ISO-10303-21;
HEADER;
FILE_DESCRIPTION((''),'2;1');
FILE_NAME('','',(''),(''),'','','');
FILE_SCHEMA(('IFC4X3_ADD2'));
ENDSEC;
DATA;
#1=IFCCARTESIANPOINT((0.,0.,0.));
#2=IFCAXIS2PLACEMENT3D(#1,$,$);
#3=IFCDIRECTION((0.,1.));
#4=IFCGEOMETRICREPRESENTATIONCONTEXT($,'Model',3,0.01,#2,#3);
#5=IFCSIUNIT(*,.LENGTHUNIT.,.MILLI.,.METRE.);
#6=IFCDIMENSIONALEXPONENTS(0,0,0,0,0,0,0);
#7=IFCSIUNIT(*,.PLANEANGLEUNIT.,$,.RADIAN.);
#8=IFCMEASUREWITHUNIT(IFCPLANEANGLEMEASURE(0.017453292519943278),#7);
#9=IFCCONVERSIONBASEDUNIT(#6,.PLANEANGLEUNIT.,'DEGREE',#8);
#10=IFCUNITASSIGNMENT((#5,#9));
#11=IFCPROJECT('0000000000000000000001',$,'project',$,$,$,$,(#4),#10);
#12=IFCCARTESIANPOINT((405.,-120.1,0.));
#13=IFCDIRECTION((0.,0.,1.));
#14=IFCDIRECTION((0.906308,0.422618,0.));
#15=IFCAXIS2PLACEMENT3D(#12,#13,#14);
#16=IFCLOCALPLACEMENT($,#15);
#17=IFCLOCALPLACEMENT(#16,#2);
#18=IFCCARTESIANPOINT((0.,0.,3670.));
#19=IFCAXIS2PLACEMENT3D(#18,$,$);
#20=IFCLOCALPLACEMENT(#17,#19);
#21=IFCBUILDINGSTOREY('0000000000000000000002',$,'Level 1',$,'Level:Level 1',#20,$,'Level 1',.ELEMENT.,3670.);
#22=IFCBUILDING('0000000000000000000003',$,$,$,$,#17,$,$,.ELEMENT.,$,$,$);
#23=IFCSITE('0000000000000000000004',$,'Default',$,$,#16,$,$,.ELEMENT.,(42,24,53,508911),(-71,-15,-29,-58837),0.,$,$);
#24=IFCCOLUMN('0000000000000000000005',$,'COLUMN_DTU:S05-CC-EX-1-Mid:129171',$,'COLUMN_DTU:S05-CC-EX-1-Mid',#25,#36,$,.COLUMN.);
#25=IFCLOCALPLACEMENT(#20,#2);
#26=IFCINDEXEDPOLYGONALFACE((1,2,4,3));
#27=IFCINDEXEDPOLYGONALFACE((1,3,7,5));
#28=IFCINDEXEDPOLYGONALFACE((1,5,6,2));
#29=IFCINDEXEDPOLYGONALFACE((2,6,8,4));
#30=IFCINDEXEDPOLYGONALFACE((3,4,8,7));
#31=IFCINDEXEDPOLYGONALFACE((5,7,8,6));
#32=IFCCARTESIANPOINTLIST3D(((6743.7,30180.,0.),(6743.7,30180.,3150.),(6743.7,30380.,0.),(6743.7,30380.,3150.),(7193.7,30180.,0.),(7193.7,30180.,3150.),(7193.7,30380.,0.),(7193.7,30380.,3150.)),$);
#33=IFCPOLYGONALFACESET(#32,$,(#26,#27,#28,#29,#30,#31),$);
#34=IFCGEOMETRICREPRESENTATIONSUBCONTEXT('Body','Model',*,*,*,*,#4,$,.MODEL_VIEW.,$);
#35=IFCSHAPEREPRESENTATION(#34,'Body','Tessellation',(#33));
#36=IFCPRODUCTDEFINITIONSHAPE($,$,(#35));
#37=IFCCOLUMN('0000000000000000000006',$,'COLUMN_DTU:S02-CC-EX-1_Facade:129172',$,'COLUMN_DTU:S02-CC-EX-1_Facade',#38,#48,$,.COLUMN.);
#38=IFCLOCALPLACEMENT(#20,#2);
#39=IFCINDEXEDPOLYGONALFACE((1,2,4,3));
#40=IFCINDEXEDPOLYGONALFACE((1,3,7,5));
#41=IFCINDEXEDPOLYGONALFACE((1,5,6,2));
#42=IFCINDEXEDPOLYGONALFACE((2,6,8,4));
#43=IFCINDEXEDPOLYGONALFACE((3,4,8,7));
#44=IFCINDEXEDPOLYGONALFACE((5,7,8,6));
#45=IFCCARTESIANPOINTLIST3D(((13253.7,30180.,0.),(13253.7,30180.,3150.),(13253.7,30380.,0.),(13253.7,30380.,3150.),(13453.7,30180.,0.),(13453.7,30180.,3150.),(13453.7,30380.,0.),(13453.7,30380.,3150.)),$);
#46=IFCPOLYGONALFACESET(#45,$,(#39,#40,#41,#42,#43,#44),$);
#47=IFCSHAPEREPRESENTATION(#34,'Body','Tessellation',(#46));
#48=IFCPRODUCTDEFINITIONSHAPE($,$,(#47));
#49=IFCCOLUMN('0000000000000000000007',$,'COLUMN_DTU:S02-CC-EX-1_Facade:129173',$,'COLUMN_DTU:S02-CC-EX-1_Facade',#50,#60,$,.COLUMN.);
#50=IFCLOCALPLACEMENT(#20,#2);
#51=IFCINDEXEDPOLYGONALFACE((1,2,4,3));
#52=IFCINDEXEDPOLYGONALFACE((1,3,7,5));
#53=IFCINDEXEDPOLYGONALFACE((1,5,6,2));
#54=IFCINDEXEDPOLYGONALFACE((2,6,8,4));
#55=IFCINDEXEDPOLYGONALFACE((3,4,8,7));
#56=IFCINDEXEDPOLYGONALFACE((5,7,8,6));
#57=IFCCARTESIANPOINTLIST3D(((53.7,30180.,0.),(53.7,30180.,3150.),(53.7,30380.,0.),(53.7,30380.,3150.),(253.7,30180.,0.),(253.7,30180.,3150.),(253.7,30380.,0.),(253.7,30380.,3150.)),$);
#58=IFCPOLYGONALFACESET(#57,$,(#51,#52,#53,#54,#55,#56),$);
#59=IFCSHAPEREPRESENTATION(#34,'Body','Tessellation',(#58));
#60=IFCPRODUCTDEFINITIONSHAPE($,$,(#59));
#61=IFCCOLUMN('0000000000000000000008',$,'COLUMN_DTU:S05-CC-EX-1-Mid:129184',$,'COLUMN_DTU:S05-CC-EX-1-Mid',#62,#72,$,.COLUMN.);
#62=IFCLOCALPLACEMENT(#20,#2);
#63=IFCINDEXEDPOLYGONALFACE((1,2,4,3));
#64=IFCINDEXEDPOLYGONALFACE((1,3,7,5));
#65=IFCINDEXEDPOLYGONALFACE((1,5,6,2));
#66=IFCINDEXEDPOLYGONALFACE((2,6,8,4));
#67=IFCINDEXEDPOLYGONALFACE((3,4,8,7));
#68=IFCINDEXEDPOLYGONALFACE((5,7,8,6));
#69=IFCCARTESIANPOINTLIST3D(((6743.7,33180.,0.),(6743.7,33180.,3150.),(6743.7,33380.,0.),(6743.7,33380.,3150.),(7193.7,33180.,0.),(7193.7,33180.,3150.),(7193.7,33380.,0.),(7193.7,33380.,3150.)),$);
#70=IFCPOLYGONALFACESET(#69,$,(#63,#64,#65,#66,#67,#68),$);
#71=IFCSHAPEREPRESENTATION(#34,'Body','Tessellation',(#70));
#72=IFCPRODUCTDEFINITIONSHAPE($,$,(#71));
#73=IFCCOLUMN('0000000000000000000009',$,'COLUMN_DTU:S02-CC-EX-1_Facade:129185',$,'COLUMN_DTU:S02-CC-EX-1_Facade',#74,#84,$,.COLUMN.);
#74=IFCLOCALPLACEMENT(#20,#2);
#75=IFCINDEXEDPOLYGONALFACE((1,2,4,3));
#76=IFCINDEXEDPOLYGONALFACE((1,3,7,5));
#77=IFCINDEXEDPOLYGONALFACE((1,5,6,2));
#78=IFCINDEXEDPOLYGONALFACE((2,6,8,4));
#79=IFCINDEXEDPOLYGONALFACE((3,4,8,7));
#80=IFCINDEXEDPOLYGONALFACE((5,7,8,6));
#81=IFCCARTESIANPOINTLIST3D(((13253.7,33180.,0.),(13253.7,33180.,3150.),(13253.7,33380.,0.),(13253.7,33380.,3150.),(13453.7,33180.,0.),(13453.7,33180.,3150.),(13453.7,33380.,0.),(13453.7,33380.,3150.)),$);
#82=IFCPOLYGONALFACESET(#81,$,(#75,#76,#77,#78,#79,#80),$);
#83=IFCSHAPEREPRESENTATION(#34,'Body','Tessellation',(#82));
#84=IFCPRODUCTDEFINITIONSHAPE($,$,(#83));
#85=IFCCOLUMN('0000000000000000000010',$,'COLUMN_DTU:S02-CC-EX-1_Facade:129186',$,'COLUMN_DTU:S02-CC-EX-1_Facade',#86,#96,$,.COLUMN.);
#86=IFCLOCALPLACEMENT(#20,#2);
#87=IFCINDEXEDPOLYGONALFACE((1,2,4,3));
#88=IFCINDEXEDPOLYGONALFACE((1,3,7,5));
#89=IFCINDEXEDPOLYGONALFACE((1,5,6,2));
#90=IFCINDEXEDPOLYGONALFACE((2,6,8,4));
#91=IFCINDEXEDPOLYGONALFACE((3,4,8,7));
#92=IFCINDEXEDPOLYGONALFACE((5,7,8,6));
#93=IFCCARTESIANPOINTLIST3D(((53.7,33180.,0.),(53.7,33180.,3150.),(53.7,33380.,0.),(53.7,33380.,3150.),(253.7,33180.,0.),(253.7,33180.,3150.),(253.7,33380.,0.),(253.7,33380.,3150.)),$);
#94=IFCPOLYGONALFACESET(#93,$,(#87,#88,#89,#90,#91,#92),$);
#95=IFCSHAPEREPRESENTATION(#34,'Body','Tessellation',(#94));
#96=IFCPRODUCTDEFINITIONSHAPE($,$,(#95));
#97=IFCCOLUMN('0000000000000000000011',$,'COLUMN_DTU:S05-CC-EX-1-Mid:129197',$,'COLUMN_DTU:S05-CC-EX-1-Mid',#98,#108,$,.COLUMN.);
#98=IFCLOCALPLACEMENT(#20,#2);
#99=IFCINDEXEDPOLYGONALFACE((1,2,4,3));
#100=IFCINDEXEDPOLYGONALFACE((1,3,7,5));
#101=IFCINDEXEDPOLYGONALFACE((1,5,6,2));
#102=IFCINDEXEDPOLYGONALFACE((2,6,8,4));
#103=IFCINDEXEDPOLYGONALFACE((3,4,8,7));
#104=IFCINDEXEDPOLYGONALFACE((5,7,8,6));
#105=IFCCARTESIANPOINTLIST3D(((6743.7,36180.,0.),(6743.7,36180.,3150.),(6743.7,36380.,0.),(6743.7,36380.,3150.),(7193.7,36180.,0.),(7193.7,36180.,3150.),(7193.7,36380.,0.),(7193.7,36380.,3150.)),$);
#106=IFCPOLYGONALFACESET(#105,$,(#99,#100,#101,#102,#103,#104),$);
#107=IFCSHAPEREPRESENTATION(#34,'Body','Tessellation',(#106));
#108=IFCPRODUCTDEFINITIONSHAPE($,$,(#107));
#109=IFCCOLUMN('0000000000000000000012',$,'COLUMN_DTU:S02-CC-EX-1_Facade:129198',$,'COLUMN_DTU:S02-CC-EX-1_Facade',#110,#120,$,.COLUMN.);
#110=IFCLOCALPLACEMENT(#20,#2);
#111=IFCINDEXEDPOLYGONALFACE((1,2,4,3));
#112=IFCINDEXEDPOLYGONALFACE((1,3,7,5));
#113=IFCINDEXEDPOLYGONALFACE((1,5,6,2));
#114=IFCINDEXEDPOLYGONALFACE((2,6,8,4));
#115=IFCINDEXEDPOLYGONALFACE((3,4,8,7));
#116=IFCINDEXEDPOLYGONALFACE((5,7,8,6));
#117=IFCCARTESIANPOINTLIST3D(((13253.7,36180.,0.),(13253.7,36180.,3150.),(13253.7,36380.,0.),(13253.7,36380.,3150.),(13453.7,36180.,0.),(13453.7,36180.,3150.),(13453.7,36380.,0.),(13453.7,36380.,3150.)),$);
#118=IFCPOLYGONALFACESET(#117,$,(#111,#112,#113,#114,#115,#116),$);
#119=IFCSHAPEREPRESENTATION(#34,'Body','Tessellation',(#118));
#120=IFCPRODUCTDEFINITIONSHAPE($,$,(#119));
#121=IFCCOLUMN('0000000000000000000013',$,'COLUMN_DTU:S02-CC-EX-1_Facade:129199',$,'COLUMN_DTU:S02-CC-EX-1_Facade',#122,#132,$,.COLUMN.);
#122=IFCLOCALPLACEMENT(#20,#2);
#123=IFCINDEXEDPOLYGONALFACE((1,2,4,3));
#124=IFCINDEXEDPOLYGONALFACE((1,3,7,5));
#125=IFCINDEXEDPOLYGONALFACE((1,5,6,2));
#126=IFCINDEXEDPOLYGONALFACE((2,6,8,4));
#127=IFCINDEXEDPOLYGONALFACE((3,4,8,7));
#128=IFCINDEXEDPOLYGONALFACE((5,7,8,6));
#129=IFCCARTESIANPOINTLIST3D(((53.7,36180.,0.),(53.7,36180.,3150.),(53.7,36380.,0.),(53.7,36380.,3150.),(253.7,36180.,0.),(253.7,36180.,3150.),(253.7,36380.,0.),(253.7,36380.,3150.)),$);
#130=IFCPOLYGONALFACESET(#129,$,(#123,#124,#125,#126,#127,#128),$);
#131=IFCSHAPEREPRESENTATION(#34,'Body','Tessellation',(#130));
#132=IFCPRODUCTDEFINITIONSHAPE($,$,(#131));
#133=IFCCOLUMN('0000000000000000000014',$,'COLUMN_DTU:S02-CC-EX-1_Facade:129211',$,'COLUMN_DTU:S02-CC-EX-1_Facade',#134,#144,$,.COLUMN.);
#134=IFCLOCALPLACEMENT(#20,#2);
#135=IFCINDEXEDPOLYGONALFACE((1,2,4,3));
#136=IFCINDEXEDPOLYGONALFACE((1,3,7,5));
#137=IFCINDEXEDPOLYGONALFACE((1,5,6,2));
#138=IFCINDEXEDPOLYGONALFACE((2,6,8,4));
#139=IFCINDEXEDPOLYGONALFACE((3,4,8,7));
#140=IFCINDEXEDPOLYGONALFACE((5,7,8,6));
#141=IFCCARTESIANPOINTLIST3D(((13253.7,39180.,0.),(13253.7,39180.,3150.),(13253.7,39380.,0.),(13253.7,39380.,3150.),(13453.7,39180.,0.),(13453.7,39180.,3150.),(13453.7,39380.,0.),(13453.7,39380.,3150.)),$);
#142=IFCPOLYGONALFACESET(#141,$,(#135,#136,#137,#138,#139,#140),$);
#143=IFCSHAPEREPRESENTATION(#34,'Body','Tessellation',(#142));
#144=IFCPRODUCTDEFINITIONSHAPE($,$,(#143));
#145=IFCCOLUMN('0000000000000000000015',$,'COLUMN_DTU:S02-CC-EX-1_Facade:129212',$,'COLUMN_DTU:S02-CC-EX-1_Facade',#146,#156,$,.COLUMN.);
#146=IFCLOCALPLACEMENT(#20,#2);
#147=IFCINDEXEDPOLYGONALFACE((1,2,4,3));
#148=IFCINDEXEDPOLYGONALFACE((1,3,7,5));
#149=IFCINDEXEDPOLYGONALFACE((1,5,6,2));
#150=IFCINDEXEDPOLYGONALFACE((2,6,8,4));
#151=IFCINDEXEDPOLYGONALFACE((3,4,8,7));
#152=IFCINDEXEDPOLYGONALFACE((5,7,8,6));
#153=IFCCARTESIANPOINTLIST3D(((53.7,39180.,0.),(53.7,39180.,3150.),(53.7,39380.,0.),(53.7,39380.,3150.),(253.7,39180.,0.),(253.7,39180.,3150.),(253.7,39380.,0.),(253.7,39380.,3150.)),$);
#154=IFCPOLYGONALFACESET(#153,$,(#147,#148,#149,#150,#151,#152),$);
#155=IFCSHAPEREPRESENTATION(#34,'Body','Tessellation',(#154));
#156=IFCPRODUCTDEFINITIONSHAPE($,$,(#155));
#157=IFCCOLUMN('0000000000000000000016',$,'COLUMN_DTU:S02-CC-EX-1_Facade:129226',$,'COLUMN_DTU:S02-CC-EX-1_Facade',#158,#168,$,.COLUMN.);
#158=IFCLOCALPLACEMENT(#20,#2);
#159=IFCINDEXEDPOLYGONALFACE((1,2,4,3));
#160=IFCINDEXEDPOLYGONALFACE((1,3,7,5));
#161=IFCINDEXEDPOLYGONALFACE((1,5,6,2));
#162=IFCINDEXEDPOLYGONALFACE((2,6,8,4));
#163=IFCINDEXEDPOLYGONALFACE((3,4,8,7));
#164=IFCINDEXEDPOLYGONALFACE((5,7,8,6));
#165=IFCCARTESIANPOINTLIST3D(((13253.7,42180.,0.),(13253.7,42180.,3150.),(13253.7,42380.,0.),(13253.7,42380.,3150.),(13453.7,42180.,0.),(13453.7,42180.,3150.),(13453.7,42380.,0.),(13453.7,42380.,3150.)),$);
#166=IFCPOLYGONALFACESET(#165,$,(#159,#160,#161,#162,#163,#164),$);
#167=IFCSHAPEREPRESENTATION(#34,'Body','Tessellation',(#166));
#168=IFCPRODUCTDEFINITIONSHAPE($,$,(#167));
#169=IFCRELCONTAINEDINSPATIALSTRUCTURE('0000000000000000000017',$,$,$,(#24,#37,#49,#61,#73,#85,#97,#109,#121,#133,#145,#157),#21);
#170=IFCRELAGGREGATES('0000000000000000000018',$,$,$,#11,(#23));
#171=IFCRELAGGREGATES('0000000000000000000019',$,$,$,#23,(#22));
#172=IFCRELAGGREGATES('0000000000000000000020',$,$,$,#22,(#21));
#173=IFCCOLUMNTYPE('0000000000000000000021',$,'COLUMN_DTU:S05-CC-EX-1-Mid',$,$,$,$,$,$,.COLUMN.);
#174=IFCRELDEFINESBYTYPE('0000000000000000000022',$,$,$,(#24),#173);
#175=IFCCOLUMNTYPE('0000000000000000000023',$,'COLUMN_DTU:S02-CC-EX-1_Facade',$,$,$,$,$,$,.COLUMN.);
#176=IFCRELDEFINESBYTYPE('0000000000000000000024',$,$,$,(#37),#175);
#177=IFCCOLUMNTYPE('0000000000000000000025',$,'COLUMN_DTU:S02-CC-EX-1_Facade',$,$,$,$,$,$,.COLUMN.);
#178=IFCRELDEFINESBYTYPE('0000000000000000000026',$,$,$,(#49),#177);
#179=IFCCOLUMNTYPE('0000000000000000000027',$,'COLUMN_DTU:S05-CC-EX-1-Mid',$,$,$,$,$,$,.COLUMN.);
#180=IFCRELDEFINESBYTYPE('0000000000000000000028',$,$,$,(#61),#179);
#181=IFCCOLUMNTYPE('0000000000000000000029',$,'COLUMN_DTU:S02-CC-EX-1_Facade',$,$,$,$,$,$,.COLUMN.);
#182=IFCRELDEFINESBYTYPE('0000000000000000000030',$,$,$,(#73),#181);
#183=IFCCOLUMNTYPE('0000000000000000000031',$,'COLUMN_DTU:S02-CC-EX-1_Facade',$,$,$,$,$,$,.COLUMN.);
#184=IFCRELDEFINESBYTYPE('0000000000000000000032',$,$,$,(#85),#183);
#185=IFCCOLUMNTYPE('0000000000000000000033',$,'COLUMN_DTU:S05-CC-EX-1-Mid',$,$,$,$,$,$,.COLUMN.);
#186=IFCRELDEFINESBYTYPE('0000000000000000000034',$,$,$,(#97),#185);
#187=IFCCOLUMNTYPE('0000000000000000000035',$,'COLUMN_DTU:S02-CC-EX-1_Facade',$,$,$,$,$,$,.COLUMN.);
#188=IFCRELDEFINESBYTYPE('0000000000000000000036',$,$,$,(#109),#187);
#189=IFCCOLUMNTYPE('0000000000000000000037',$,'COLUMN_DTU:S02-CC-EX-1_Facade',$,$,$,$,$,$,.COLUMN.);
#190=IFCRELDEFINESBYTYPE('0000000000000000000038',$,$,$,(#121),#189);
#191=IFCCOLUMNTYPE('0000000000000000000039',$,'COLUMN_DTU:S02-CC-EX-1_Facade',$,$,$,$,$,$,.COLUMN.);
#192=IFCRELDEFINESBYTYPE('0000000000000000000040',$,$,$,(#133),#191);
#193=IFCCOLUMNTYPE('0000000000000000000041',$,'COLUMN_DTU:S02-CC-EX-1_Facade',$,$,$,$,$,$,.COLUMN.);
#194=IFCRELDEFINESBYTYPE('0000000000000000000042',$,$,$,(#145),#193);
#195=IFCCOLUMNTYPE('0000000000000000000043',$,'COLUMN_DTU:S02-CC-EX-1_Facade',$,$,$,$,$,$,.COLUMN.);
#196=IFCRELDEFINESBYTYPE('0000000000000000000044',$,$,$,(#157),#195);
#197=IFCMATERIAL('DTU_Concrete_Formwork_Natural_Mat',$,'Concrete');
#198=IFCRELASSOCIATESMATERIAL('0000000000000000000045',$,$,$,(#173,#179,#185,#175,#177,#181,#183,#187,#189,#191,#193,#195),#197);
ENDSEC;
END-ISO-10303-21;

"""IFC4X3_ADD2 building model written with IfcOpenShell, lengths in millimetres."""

from ifc_helpers import new_model, entity, si_unit, converted_unit, direction, frame, frame_2d, origin, origin_2d_with_axis, place, context, subcontext, project, spatial, rectangle, extrude, source, transform, mapped, material, material_profile, profile_set, type_object, type_shapes, element, save


model = new_model("IFC4X3_ADD2")

# Units and contexts
model_context = context("Model", 3, precision=0.01, world=origin(), true_north=direction((0.0, 1.0)))
body_context = subcontext(model_context, "Body", "Model", "MODEL_VIEW")
ifc_project = project(units=[si_unit("LENGTHUNIT", "METRE", prefix="MILLI"), converted_unit("PLANEANGLEUNIT", "DEGREE", entity("IfcPlaneAngleMeasure", 0.017453292519943278), si_unit("PLANEANGLEUNIT", "RADIAN"), dimensions=[0, 0, 0, 0, 0, 0, 0])], contexts=[model_context])

# Site, building, storey
site_placement = place(None, frame((405.0, -120.1, 0.0), z_axis=(0.0, 0.0, 1.0), x_axis=(0.906308, 0.422618, 0.0)))
site = spatial("IfcSite", under=ifc_project, at=site_placement, Name="Default", CompositionType="ELEMENT", RefLatitude=(42, 24, 53, 508911), RefLongitude=(-71, -15, -29, -58837), RefElevation=0.0)
building_placement = place(site_placement, origin())
building = spatial("IfcBuilding", under=site, at=building_placement, CompositionType="ELEMENT")
storey_placement = place(building_placement, frame((0.0, 0.0, 3670.0)))
storey = spatial("IfcBuildingStorey", under=building, at=storey_placement, Name="Level 1", ObjectType="Level:Level 1", LongName="Level 1", CompositionType="ELEMENT", Elevation=3670.0)

# Columns
ifc_material = material(Name="DTU_Concrete_Formwork_Natural_Mat", Category="Concrete")
ifc_material_profile_1 = material_profile(ifc_material, rectangle(XDim=200.0, YDim=450.0, at=origin_2d_with_axis()), Name="S05-CC-EX-1-Mid")
ifc_profile_set_1 = profile_set([ifc_material_profile_1], Name="S05-CC-EX-1-Mid")
column_type_1 = type_object("IfcColumnType", Name="COLUMN_DTU:S05-CC-EX-1-Mid", PredefinedType="COLUMN", material=ifc_profile_set_1)
shared_shape_1 = source(origin(), body_context, "Body", "SweptSolid", [
    extrude(rectangle(XDim=200.0, YDim=450.0, at=origin_2d_with_axis()), frame((6968.7, 30280.0, 3670.0), z_axis=(0.0, 0.0, 1.0), x_axis=(0.0, 1.0, 0.0)), (0.0, 0.0, 1.0), 3150.0),
])
type_shapes(column_type_1, [shared_shape_1])
column_1_placement = place(storey_placement, frame((0.0, 0.0, -3670.0)))
element("IfcColumn", 1, at=column_1_placement, inside=storey, type_object=column_type_1, Name="COLUMN_DTU:S05-CC-EX-1-Mid:129171", ObjectType="COLUMN_DTU:S05-CC-EX-1-Mid", PredefinedType="COLUMN", context=body_context, shape_type="MappedRepresentation", body=[
    mapped(shared_shape_1, transform((0.0, 0.0, 0.0), scale=1.0)),
])
ifc_material_profile_2 = material_profile(ifc_material, rectangle(XDim=200.0, YDim=200.0, at=frame_2d((0.0, 0.0), x_axis=(1.0, 0.0))), Name="S02-CC-EX-1_Facade")
ifc_profile_set_2 = profile_set([ifc_material_profile_2], Name="S02-CC-EX-1_Facade")
column_type_2 = type_object("IfcColumnType", Name="COLUMN_DTU:S02-CC-EX-1_Facade", PredefinedType="COLUMN", material=ifc_profile_set_2)
shared_shape_2 = source(origin(), body_context, "Body", "SweptSolid", [
    extrude(rectangle(XDim=200.0, YDim=200.0, at=frame_2d((0.0, 0.0), x_axis=(1.0, 0.0))), frame((13353.7, 30280.0, 3670.0), z_axis=(0.0, 0.0, 1.0), x_axis=(0.0, -1.0, 0.0)), (0.0, 0.0, 1.0), 3150.0),
])
type_shapes(column_type_2, [shared_shape_2])
column_2_placement = place(storey_placement, frame((0.0, 0.0, -3670.0)))
element("IfcColumn", 2, at=column_2_placement, inside=storey, type_object=column_type_2, Name="COLUMN_DTU:S02-CC-EX-1_Facade:129172", ObjectType="COLUMN_DTU:S02-CC-EX-1_Facade", PredefinedType="COLUMN", context=body_context, shape_type="MappedRepresentation", body=[
    mapped(shared_shape_2, transform((0.0, 0.0, 0.0), scale=1.0)),
])
column_type_3 = type_object("IfcColumnType", Name="COLUMN_DTU:S02-CC-EX-1_Facade", PredefinedType="COLUMN", material=ifc_profile_set_2)
shared_shape_3 = source(origin(), body_context, "Body", "SweptSolid", [
    extrude(rectangle(XDim=200.0, YDim=200.0, at=frame_2d((0.0, 0.0), x_axis=(1.0, 0.0))), frame((153.7, 30280.0, 3670.0), z_axis=(0.0, 0.0, 1.0), x_axis=(0.0, -1.0, 0.0)), (0.0, 0.0, 1.0), 3150.0),
])
type_shapes(column_type_3, [shared_shape_3])
column_3_placement = place(storey_placement, frame((0.0, 0.0, -3670.0)))
element("IfcColumn", 3, at=column_3_placement, inside=storey, type_object=column_type_3, Name="COLUMN_DTU:S02-CC-EX-1_Facade:129173", ObjectType="COLUMN_DTU:S02-CC-EX-1_Facade", PredefinedType="COLUMN", context=body_context, shape_type="MappedRepresentation", body=[
    mapped(shared_shape_3, transform((0.0, 0.0, 0.0), scale=1.0)),
])
column_type_4 = type_object("IfcColumnType", Name="COLUMN_DTU:S05-CC-EX-1-Mid", PredefinedType="COLUMN", material=ifc_profile_set_1)
shared_shape_4 = source(origin(), body_context, "Body", "SweptSolid", [
    extrude(rectangle(XDim=200.0, YDim=450.0, at=origin_2d_with_axis()), frame((6968.7, 33280.0, 3670.0), z_axis=(0.0, 0.0, 1.0), x_axis=(0.0, 1.0, 0.0)), (0.0, 0.0, 1.0), 3150.0),
])
type_shapes(column_type_4, [shared_shape_4])
column_4_placement = place(storey_placement, frame((0.0, 0.0, -3670.0)))
element("IfcColumn", 4, at=column_4_placement, inside=storey, type_object=column_type_4, Name="COLUMN_DTU:S05-CC-EX-1-Mid:129184", ObjectType="COLUMN_DTU:S05-CC-EX-1-Mid", PredefinedType="COLUMN", context=body_context, shape_type="MappedRepresentation", body=[
    mapped(shared_shape_4, transform((0.0, 0.0, 0.0), scale=1.0)),
])
column_type_5 = type_object("IfcColumnType", Name="COLUMN_DTU:S02-CC-EX-1_Facade", PredefinedType="COLUMN", material=ifc_profile_set_2)
shared_shape_5 = source(origin(), body_context, "Body", "SweptSolid", [
    extrude(rectangle(XDim=200.0, YDim=200.0, at=frame_2d((0.0, 0.0), x_axis=(1.0, 0.0))), frame((13353.7, 33280.0, 3670.0), z_axis=(0.0, 0.0, 1.0), x_axis=(0.0, -1.0, 0.0)), (0.0, 0.0, 1.0), 3150.0),
])
type_shapes(column_type_5, [shared_shape_5])
column_5_placement = place(storey_placement, frame((0.0, 0.0, -3670.0)))
element("IfcColumn", 5, at=column_5_placement, inside=storey, type_object=column_type_5, Name="COLUMN_DTU:S02-CC-EX-1_Facade:129185", ObjectType="COLUMN_DTU:S02-CC-EX-1_Facade", PredefinedType="COLUMN", context=body_context, shape_type="MappedRepresentation", body=[
    mapped(shared_shape_5, transform((0.0, 0.0, 0.0), scale=1.0)),
])
column_type_6 = type_object("IfcColumnType", Name="COLUMN_DTU:S02-CC-EX-1_Facade", PredefinedType="COLUMN", material=ifc_profile_set_2)
shared_shape_6 = source(origin(), body_context, "Body", "SweptSolid", [
    extrude(rectangle(XDim=200.0, YDim=200.0, at=frame_2d((0.0, 0.0), x_axis=(1.0, 0.0))), frame((153.7, 33280.0, 3670.0), z_axis=(0.0, 0.0, 1.0), x_axis=(0.0, -1.0, 0.0)), (0.0, 0.0, 1.0), 3150.0),
])
type_shapes(column_type_6, [shared_shape_6])
column_6_placement = place(storey_placement, frame((0.0, 0.0, -3670.0)))
element("IfcColumn", 6, at=column_6_placement, inside=storey, type_object=column_type_6, Name="COLUMN_DTU:S02-CC-EX-1_Facade:129186", ObjectType="COLUMN_DTU:S02-CC-EX-1_Facade", PredefinedType="COLUMN", context=body_context, shape_type="MappedRepresentation", body=[
    mapped(shared_shape_6, transform((0.0, 0.0, 0.0), scale=1.0)),
])
column_type_7 = type_object("IfcColumnType", Name="COLUMN_DTU:S05-CC-EX-1-Mid", PredefinedType="COLUMN", material=ifc_profile_set_1)
shared_shape_7 = source(origin(), body_context, "Body", "SweptSolid", [
    extrude(rectangle(XDim=200.0, YDim=450.0, at=origin_2d_with_axis()), frame((6968.7, 36280.0, 3670.0), z_axis=(0.0, 0.0, 1.0), x_axis=(0.0, 1.0, 0.0)), (0.0, 0.0, 1.0), 3150.0),
])
type_shapes(column_type_7, [shared_shape_7])
column_7_placement = place(storey_placement, frame((0.0, 0.0, -3670.0)))
element("IfcColumn", 7, at=column_7_placement, inside=storey, type_object=column_type_7, Name="COLUMN_DTU:S05-CC-EX-1-Mid:129197", ObjectType="COLUMN_DTU:S05-CC-EX-1-Mid", PredefinedType="COLUMN", context=body_context, shape_type="MappedRepresentation", body=[
    mapped(shared_shape_7, transform((0.0, 0.0, 0.0), scale=1.0)),
])
column_type_8 = type_object("IfcColumnType", Name="COLUMN_DTU:S02-CC-EX-1_Facade", PredefinedType="COLUMN", material=ifc_profile_set_2)
shared_shape_8 = source(origin(), body_context, "Body", "SweptSolid", [
    extrude(rectangle(XDim=200.0, YDim=200.0, at=frame_2d((0.0, 0.0), x_axis=(1.0, 0.0))), frame((13353.7, 36280.0, 3670.0), z_axis=(0.0, 0.0, 1.0), x_axis=(0.0, -1.0, 0.0)), (0.0, 0.0, 1.0), 3150.0),
])
type_shapes(column_type_8, [shared_shape_8])
column_8_placement = place(storey_placement, frame((0.0, 0.0, -3670.0)))
element("IfcColumn", 8, at=column_8_placement, inside=storey, type_object=column_type_8, Name="COLUMN_DTU:S02-CC-EX-1_Facade:129198", ObjectType="COLUMN_DTU:S02-CC-EX-1_Facade", PredefinedType="COLUMN", context=body_context, shape_type="MappedRepresentation", body=[
    mapped(shared_shape_8, transform((0.0, 0.0, 0.0), scale=1.0)),
])
column_type_9 = type_object("IfcColumnType", Name="COLUMN_DTU:S02-CC-EX-1_Facade", PredefinedType="COLUMN", material=ifc_profile_set_2)
shared_shape_9 = source(origin(), body_context, "Body", "SweptSolid", [
    extrude(rectangle(XDim=200.0, YDim=200.0, at=frame_2d((0.0, 0.0), x_axis=(1.0, 0.0))), frame((153.7, 36280.0, 3670.0), z_axis=(0.0, 0.0, 1.0), x_axis=(0.0, -1.0, 0.0)), (0.0, 0.0, 1.0), 3150.0),
])
type_shapes(column_type_9, [shared_shape_9])
column_9_placement = place(storey_placement, frame((0.0, 0.0, -3670.0)))
element("IfcColumn", 9, at=column_9_placement, inside=storey, type_object=column_type_9, Name="COLUMN_DTU:S02-CC-EX-1_Facade:129199", ObjectType="COLUMN_DTU:S02-CC-EX-1_Facade", PredefinedType="COLUMN", context=body_context, shape_type="MappedRepresentation", body=[
    mapped(shared_shape_9, transform((0.0, 0.0, 0.0), scale=1.0)),
])
column_type_10 = type_object("IfcColumnType", Name="COLUMN_DTU:S02-CC-EX-1_Facade", PredefinedType="COLUMN", material=ifc_profile_set_2)
shared_shape_10 = source(origin(), body_context, "Body", "SweptSolid", [
    extrude(rectangle(XDim=200.0, YDim=200.0, at=frame_2d((0.0, 0.0), x_axis=(1.0, 0.0))), frame((13353.7, 39280.0, 3670.0), z_axis=(0.0, 0.0, 1.0), x_axis=(0.0, -1.0, 0.0)), (0.0, 0.0, 1.0), 3150.0),
])
type_shapes(column_type_10, [shared_shape_10])
column_10_placement = place(storey_placement, frame((0.0, 0.0, -3670.0)))
element("IfcColumn", 10, at=column_10_placement, inside=storey, type_object=column_type_10, Name="COLUMN_DTU:S02-CC-EX-1_Facade:129211", ObjectType="COLUMN_DTU:S02-CC-EX-1_Facade", PredefinedType="COLUMN", context=body_context, shape_type="MappedRepresentation", body=[
    mapped(shared_shape_10, transform((0.0, 0.0, 0.0), scale=1.0)),
])
column_type_11 = type_object("IfcColumnType", Name="COLUMN_DTU:S02-CC-EX-1_Facade", PredefinedType="COLUMN", material=ifc_profile_set_2)
shared_shape_11 = source(origin(), body_context, "Body", "SweptSolid", [
    extrude(rectangle(XDim=200.0, YDim=200.0, at=frame_2d((0.0, 0.0), x_axis=(1.0, 0.0))), frame((153.7, 39280.0, 3670.0), z_axis=(0.0, 0.0, 1.0), x_axis=(0.0, -1.0, 0.0)), (0.0, 0.0, 1.0), 3150.0),
])
type_shapes(column_type_11, [shared_shape_11])
column_11_placement = place(storey_placement, frame((0.0, 0.0, -3670.0)))
element("IfcColumn", 11, at=column_11_placement, inside=storey, type_object=column_type_11, Name="COLUMN_DTU:S02-CC-EX-1_Facade:129212", ObjectType="COLUMN_DTU:S02-CC-EX-1_Facade", PredefinedType="COLUMN", context=body_context, shape_type="MappedRepresentation", body=[
    mapped(shared_shape_11, transform((0.0, 0.0, 0.0), scale=1.0)),
])
column_type_12 = type_object("IfcColumnType", Name="COLUMN_DTU:S02-CC-EX-1_Facade", PredefinedType="COLUMN", material=ifc_profile_set_2)
shared_shape_12 = source(origin(), body_context, "Body", "SweptSolid", [
    extrude(rectangle(XDim=200.0, YDim=200.0, at=frame_2d((0.0, 0.0), x_axis=(1.0, 0.0))), frame((13353.7, 42280.0, 3670.0), z_axis=(0.0, 0.0, 1.0), x_axis=(0.0, -1.0, 0.0)), (0.0, 0.0, 1.0), 3150.0),
])
type_shapes(column_type_12, [shared_shape_12])
column_12_placement = place(storey_placement, frame((0.0, 0.0, -3670.0)))
element("IfcColumn", 12, at=column_12_placement, inside=storey, type_object=column_type_12, Name="COLUMN_DTU:S02-CC-EX-1_Facade:129226", ObjectType="COLUMN_DTU:S02-CC-EX-1_Facade", PredefinedType="COLUMN", context=body_context, shape_type="MappedRepresentation", body=[
    mapped(shared_shape_12, transform((0.0, 0.0, 0.0), scale=1.0)),
])

save(model, "model.ifc")
